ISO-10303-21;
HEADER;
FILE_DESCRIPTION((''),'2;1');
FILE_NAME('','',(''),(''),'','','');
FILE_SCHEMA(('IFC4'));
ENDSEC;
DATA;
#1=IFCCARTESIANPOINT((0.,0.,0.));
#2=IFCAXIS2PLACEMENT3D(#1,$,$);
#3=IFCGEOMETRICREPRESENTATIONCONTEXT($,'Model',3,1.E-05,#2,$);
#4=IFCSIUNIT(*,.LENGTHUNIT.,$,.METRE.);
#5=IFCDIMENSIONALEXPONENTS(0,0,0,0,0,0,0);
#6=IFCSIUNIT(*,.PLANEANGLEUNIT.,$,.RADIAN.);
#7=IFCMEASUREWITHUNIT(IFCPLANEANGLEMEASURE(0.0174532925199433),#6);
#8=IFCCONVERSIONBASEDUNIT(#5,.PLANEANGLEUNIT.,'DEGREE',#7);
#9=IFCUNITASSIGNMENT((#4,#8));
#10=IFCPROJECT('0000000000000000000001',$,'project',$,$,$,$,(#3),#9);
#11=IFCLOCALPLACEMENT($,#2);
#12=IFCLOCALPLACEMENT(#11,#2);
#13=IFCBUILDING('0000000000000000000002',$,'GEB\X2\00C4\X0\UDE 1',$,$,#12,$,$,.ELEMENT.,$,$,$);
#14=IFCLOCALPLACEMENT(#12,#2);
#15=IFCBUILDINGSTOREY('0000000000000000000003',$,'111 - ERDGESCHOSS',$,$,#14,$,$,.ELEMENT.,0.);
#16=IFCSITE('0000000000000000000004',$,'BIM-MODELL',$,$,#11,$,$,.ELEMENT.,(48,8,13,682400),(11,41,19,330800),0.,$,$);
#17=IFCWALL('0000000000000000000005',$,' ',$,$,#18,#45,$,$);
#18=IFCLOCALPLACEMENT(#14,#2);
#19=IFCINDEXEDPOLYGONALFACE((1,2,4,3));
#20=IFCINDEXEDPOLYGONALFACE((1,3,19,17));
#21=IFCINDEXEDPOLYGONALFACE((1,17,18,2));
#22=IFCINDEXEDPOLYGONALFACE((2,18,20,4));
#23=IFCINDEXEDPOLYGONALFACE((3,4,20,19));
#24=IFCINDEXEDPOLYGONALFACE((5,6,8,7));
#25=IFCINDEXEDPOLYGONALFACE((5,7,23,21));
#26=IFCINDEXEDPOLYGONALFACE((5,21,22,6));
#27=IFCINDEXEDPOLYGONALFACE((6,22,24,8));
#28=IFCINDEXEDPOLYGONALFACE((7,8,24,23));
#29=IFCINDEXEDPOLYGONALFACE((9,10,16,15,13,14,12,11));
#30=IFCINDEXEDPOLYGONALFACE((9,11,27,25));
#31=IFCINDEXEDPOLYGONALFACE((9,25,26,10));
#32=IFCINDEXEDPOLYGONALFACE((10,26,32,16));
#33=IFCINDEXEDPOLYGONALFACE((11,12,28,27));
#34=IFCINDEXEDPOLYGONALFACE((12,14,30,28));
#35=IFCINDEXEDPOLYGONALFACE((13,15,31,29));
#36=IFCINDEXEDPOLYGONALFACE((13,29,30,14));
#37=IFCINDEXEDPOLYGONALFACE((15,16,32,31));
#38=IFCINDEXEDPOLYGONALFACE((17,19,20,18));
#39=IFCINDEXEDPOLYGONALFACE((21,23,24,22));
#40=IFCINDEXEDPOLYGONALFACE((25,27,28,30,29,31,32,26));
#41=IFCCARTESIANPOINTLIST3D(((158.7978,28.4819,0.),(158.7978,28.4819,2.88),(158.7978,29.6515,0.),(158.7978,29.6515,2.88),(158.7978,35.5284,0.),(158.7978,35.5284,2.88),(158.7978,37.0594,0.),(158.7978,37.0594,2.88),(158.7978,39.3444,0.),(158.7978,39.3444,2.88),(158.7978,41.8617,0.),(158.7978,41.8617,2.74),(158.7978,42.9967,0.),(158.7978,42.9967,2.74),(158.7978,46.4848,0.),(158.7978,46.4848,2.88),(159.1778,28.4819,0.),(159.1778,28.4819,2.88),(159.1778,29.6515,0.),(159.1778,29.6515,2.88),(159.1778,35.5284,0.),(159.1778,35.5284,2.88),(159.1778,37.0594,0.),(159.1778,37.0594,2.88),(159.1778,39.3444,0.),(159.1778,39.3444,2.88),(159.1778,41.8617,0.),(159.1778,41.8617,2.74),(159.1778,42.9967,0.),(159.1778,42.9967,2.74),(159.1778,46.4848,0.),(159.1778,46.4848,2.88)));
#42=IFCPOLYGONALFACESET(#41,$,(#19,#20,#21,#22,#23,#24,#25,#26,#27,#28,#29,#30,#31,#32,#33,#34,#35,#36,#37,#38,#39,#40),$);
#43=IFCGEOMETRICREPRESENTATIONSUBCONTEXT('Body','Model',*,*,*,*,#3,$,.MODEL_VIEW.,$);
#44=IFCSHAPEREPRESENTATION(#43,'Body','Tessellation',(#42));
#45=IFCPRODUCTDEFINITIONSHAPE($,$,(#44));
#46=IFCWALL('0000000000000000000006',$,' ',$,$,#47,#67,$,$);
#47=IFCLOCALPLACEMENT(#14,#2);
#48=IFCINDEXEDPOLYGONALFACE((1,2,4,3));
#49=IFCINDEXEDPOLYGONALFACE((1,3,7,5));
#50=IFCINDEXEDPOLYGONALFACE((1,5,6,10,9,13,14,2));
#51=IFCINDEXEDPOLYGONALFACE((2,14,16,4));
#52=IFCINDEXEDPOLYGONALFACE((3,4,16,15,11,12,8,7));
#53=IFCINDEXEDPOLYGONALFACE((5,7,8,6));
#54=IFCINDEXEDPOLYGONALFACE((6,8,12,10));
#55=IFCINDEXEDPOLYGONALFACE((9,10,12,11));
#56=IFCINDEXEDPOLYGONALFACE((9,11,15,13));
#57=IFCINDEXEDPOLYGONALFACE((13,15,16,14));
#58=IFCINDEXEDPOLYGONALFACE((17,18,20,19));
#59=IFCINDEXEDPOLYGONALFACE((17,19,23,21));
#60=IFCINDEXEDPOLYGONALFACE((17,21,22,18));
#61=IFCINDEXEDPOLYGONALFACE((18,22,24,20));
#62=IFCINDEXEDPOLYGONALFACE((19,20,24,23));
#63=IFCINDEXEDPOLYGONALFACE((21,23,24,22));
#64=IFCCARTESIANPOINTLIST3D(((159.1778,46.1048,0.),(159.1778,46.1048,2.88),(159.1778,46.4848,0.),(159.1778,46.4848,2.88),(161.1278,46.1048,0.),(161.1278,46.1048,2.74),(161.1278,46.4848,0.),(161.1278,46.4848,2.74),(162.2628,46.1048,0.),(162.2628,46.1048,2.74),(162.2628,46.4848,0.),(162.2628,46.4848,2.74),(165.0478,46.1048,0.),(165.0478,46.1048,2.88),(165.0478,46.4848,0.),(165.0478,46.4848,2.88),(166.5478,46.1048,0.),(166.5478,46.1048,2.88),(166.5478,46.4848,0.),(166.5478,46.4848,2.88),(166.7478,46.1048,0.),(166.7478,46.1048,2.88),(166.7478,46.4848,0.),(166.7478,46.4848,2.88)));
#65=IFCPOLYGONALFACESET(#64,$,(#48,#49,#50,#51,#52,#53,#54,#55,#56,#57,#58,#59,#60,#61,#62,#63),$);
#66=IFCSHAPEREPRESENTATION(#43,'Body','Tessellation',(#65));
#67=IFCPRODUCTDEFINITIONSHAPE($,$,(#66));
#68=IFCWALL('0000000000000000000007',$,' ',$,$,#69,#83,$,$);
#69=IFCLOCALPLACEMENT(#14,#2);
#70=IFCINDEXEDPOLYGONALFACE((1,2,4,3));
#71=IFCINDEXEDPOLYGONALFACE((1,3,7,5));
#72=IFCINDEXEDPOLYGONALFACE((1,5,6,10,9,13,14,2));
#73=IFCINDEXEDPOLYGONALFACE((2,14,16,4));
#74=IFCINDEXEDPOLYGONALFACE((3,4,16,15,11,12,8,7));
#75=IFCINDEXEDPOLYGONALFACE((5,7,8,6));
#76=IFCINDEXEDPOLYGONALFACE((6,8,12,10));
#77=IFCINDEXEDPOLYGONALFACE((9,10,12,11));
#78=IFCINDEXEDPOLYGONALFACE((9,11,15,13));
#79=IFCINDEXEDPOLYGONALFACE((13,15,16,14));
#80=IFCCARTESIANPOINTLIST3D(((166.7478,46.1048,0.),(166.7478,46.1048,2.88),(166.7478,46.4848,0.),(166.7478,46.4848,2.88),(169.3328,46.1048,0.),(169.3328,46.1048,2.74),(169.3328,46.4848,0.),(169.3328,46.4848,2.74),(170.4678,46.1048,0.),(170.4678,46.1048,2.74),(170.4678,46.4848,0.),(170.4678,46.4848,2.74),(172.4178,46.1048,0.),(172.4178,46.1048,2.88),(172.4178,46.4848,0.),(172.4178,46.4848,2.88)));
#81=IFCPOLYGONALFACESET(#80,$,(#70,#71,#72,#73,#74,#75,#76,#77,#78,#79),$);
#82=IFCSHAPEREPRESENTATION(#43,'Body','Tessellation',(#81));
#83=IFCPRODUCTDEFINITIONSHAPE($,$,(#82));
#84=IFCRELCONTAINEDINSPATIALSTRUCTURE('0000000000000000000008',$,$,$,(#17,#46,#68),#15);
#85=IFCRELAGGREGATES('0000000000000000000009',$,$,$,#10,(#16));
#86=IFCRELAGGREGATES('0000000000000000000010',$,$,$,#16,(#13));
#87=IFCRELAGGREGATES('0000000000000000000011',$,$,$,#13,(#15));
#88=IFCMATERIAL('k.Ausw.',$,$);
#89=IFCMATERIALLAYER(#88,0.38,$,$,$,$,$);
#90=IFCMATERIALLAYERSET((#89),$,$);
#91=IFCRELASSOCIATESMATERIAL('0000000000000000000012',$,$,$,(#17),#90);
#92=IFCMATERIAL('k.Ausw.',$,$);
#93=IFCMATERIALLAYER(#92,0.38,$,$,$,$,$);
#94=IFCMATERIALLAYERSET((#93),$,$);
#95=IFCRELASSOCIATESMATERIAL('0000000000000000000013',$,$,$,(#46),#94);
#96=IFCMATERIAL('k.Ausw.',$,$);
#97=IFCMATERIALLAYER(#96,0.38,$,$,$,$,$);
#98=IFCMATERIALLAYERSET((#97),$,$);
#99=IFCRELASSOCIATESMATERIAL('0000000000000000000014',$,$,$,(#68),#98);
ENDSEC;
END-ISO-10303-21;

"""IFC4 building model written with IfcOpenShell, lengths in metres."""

from ifc_helpers import new_model, entity, si_unit, converted_unit, frame, frame_2d, origin, origin_with_axes, place, context, subcontext, project, spatial, polyline, rectangle, outline, extrude, material, layer, layer_set, layer_usage, element, save


model = new_model("IFC4")

# Units and contexts
model_context = context("Model", 3, precision=1e-05, world=origin())
body_context = subcontext(model_context, "Body", "Model", "MODEL_VIEW")
ifc_project = project(units=[si_unit("LENGTHUNIT", "METRE"), converted_unit("PLANEANGLEUNIT", "DEGREE", entity("IfcPlaneAngleMeasure", 0.0174532925199433), si_unit("PLANEANGLEUNIT", "RADIAN"), dimensions=[0, 0, 0, 0, 0, 0, 0])], contexts=[model_context])

# Site, building, storey
site_placement = place(None, origin())
site = spatial("IfcSite", under=ifc_project, at=site_placement, Name="BIM-MODELL", CompositionType="ELEMENT", RefLatitude=(48, 8, 13, 682400), RefLongitude=(11, 41, 19, 330800), RefElevation=0.0)
building_placement = place(site_placement, origin())
building = spatial("IfcBuilding", under=site, at=building_placement, Name="GEBÄUDE 1", CompositionType="ELEMENT")
storey_placement = place(building_placement, origin())
storey = spatial("IfcBuildingStorey", under=building, at=storey_placement, Name="111 - ERDGESCHOSS", CompositionType="ELEMENT", Elevation=0.0)

# Walls, openings
ifc_material_1 = material(Name="k.Ausw.")
ifc_layer_1 = layer(ifc_material_1, 0.38)
ifc_layer_set_1 = layer_set([ifc_layer_1])
ifc_layer_usage_1 = layer_usage(ifc_layer_set_1, "AXIS2", "POSITIVE", 0.0)
wall_1_placement = place(storey_placement, frame((158.7978, 46.4848, 0.0), z_axis=(0.0, 0.0, 1.0), x_axis=(0.0, -1.0, 0.0)))
wall_1 = element("IfcWall", 1, at=wall_1_placement, inside=storey, material=ifc_layer_usage_1, Name=" ", context=body_context, shape_type="SweptSolid", body=[
    extrude(rectangle(XDim=18.0029, YDim=0.38, at=frame_2d((9.0014, 0.19), x_axis=(1.0, 0.0))), origin_with_axes(), (0.0, 0.0, 1.0), 2.88),
])
opening_1_placement = place(wall_1_placement, frame((8.2904, 0.0, 0.0), z_axis=(0.0, 1.0, 0.0), x_axis=(0.0, 0.0, 1.0)))
element("IfcOpeningElement", 2, at=opening_1_placement, cuts=wall_1, ObjectType="Opening", context=body_context, shape_type="SweptSolid", body=[
    extrude(outline(polyline([(0.0, 1.135), (2.88, 1.135), (2.88, 0.0), (0.0, 0.0), (0.0, 1.135)])), origin_with_axes(), (0.0, 0.0, 1.0), 0.38),
])
opening_2_placement = place(wall_1_placement, frame((10.9564, 0.0, 0.0), z_axis=(0.0, 1.0, 0.0), x_axis=(0.0, 0.0, 1.0)))
element("IfcOpeningElement", 3, at=opening_2_placement, cuts=wall_1, ObjectType="Opening", context=body_context, shape_type="SweptSolid", body=[
    extrude(outline(polyline([(0.0, 1.135), (2.88, 1.135), (2.88, 0.0), (0.0, 0.0), (0.0, 1.135)])), origin_with_axes(), (0.0, 0.0, 1.0), 0.38),
])
opening_3_placement = place(wall_1_placement, frame((15.6983, 0.0, 0.0), z_axis=(0.0, 1.0, 0.0), x_axis=(0.0, 0.0, 1.0)))
element("IfcOpeningElement", 4, at=opening_3_placement, cuts=wall_1, ObjectType="Opening", context=body_context, shape_type="SweptSolid", body=[
    extrude(outline(polyline([(0.0, 1.135), (2.88, 1.135), (2.88, 0.0), (0.0, 0.0), (0.0, 1.135)])), origin_with_axes(), (0.0, 0.0, 1.0), 0.38),
])
opening_4_placement = place(wall_1_placement, frame((12.0914, 0.0, 0.0), z_axis=(0.0, 1.0, 0.0), x_axis=(0.0, 0.0, 1.0)))
element("IfcOpeningElement", 5, at=opening_4_placement, cuts=wall_1, ObjectType="Opening", context=body_context, shape_type="SweptSolid", body=[
    extrude(outline(polyline([(0.0, 3.608), (2.88, 3.608), (2.88, 0.0), (0.0, 0.0), (0.0, 3.608)])), origin_with_axes(), (0.0, 0.0, 1.0), 0.38),
])
opening_5_placement = place(wall_1_placement, frame((7.1404, 0.0, 0.0), z_axis=(0.0, 1.0, 0.0), x_axis=(0.0, 0.0, 1.0)))
element("IfcOpeningElement", 6, at=opening_5_placement, cuts=wall_1, ObjectType="Opening", context=body_context, shape_type="SweptSolid", body=[
    extrude(outline(polyline([(0.0, 1.15), (2.88, 1.15), (2.88, 0.0), (0.0, 0.0), (0.0, 1.15)])), origin_with_axes(), (0.0, 0.0, 1.0), 0.38),
])
opening_6_placement = place(wall_1_placement, frame((3.4881, 0.0, 0.0), z_axis=(0.0, 1.0, 0.0), x_axis=(0.0, 0.0, 1.0)))
element("IfcOpeningElement", 7, at=opening_6_placement, cuts=wall_1, ObjectType="Opening", context=body_context, shape_type="SweptSolid", body=[
    extrude(outline(polyline([(0.0, 1.135), (2.74, 1.135), (2.74, 0.0), (0.0, 0.0), (0.0, 1.135)])), origin_with_axes(), (0.0, 0.0, 1.0), 0.38),
])
ifc_material_2 = material(Name="k.Ausw.")
ifc_layer_2 = layer(ifc_material_2, 0.38)
ifc_layer_set_2 = layer_set([ifc_layer_2])
ifc_layer_usage_2 = layer_usage(ifc_layer_set_2, "AXIS2", "POSITIVE", 0.0)
wall_2_placement = place(storey_placement, frame((166.7478, 46.4848, 0.0), z_axis=(0.0, 0.0, 1.0), x_axis=(-1.0, 0.0, 0.0)))
wall_2 = element("IfcWall", 8, at=wall_2_placement, inside=storey, material=ifc_layer_usage_2, Name=" ", context=body_context, shape_type="SweptSolid", body=[
    extrude(rectangle(XDim=7.57, YDim=0.38, at=frame_2d((3.785, 0.19), x_axis=(1.0, 0.0))), origin_with_axes(), (0.0, 0.0, 1.0), 2.88),
])
opening_7_placement = place(wall_2_placement, frame((5.62, 0.38, 0.0), z_axis=(0.0, -1.0, 0.0), x_axis=(0.0, 0.0, 1.0)))
element("IfcOpeningElement", 9, at=opening_7_placement, cuts=wall_2, ObjectType="Opening", context=body_context, shape_type="SweptSolid", body=[
    extrude(outline(polyline([(0.0, 1.135), (2.74, 1.135), (2.74, 0.0), (0.0, 0.0), (0.0, 1.135)])), origin_with_axes(), (0.0, 0.0, 1.0), 0.38),
])
opening_8_placement = place(wall_2_placement, frame((0.2, 0.0, -0.15), z_axis=(0.0, 1.0, 0.0), x_axis=(0.0, 0.0, 1.0)))
element("IfcOpeningElement", 10, at=opening_8_placement, cuts=wall_2, ObjectType="Opening", context=body_context, shape_type="SweptSolid", body=[
    extrude(outline(polyline([(0.0, 1.5), (3.03, 1.5), (3.03, 0.0), (0.0, 0.0), (0.0, 1.5)])), origin_with_axes(), (0.0, 0.0, 1.0), 0.38),
])

# Wall, opening
ifc_material_3 = material(Name="k.Ausw.")
ifc_layer_3 = layer(ifc_material_3, 0.38)
ifc_layer_set_3 = layer_set([ifc_layer_3])
ifc_layer_usage_3 = layer_usage(ifc_layer_set_3, "AXIS2", "POSITIVE", 0.0)
wall_3_placement = place(storey_placement, frame((172.4178, 46.4848, 0.0), z_axis=(0.0, 0.0, 1.0), x_axis=(-1.0, 0.0, 0.0)))
wall_3 = element("IfcWall", 11, at=wall_3_placement, inside=storey, material=ifc_layer_usage_3, Name=" ", context=body_context, shape_type="SweptSolid", body=[
    extrude(rectangle(XDim=5.67, YDim=0.38, at=frame_2d((2.835, 0.19), x_axis=(1.0, 0.0))), origin_with_axes(), (0.0, 0.0, 1.0), 2.88),
])
opening_9_placement = place(wall_3_placement, frame((3.085, 0.38, 0.0), z_axis=(0.0, -1.0, 0.0), x_axis=(0.0, 0.0, 1.0)))
element("IfcOpeningElement", 12, at=opening_9_placement, cuts=wall_3, ObjectType="Opening", context=body_context, shape_type="SweptSolid", body=[
    extrude(outline(polyline([(0.0, 1.135), (2.74, 1.135), (2.74, 0.0), (0.0, 0.0), (0.0, 1.135)])), origin_with_axes(), (0.0, 0.0, 1.0), 0.38),
])

save(model, "model.ifc")
